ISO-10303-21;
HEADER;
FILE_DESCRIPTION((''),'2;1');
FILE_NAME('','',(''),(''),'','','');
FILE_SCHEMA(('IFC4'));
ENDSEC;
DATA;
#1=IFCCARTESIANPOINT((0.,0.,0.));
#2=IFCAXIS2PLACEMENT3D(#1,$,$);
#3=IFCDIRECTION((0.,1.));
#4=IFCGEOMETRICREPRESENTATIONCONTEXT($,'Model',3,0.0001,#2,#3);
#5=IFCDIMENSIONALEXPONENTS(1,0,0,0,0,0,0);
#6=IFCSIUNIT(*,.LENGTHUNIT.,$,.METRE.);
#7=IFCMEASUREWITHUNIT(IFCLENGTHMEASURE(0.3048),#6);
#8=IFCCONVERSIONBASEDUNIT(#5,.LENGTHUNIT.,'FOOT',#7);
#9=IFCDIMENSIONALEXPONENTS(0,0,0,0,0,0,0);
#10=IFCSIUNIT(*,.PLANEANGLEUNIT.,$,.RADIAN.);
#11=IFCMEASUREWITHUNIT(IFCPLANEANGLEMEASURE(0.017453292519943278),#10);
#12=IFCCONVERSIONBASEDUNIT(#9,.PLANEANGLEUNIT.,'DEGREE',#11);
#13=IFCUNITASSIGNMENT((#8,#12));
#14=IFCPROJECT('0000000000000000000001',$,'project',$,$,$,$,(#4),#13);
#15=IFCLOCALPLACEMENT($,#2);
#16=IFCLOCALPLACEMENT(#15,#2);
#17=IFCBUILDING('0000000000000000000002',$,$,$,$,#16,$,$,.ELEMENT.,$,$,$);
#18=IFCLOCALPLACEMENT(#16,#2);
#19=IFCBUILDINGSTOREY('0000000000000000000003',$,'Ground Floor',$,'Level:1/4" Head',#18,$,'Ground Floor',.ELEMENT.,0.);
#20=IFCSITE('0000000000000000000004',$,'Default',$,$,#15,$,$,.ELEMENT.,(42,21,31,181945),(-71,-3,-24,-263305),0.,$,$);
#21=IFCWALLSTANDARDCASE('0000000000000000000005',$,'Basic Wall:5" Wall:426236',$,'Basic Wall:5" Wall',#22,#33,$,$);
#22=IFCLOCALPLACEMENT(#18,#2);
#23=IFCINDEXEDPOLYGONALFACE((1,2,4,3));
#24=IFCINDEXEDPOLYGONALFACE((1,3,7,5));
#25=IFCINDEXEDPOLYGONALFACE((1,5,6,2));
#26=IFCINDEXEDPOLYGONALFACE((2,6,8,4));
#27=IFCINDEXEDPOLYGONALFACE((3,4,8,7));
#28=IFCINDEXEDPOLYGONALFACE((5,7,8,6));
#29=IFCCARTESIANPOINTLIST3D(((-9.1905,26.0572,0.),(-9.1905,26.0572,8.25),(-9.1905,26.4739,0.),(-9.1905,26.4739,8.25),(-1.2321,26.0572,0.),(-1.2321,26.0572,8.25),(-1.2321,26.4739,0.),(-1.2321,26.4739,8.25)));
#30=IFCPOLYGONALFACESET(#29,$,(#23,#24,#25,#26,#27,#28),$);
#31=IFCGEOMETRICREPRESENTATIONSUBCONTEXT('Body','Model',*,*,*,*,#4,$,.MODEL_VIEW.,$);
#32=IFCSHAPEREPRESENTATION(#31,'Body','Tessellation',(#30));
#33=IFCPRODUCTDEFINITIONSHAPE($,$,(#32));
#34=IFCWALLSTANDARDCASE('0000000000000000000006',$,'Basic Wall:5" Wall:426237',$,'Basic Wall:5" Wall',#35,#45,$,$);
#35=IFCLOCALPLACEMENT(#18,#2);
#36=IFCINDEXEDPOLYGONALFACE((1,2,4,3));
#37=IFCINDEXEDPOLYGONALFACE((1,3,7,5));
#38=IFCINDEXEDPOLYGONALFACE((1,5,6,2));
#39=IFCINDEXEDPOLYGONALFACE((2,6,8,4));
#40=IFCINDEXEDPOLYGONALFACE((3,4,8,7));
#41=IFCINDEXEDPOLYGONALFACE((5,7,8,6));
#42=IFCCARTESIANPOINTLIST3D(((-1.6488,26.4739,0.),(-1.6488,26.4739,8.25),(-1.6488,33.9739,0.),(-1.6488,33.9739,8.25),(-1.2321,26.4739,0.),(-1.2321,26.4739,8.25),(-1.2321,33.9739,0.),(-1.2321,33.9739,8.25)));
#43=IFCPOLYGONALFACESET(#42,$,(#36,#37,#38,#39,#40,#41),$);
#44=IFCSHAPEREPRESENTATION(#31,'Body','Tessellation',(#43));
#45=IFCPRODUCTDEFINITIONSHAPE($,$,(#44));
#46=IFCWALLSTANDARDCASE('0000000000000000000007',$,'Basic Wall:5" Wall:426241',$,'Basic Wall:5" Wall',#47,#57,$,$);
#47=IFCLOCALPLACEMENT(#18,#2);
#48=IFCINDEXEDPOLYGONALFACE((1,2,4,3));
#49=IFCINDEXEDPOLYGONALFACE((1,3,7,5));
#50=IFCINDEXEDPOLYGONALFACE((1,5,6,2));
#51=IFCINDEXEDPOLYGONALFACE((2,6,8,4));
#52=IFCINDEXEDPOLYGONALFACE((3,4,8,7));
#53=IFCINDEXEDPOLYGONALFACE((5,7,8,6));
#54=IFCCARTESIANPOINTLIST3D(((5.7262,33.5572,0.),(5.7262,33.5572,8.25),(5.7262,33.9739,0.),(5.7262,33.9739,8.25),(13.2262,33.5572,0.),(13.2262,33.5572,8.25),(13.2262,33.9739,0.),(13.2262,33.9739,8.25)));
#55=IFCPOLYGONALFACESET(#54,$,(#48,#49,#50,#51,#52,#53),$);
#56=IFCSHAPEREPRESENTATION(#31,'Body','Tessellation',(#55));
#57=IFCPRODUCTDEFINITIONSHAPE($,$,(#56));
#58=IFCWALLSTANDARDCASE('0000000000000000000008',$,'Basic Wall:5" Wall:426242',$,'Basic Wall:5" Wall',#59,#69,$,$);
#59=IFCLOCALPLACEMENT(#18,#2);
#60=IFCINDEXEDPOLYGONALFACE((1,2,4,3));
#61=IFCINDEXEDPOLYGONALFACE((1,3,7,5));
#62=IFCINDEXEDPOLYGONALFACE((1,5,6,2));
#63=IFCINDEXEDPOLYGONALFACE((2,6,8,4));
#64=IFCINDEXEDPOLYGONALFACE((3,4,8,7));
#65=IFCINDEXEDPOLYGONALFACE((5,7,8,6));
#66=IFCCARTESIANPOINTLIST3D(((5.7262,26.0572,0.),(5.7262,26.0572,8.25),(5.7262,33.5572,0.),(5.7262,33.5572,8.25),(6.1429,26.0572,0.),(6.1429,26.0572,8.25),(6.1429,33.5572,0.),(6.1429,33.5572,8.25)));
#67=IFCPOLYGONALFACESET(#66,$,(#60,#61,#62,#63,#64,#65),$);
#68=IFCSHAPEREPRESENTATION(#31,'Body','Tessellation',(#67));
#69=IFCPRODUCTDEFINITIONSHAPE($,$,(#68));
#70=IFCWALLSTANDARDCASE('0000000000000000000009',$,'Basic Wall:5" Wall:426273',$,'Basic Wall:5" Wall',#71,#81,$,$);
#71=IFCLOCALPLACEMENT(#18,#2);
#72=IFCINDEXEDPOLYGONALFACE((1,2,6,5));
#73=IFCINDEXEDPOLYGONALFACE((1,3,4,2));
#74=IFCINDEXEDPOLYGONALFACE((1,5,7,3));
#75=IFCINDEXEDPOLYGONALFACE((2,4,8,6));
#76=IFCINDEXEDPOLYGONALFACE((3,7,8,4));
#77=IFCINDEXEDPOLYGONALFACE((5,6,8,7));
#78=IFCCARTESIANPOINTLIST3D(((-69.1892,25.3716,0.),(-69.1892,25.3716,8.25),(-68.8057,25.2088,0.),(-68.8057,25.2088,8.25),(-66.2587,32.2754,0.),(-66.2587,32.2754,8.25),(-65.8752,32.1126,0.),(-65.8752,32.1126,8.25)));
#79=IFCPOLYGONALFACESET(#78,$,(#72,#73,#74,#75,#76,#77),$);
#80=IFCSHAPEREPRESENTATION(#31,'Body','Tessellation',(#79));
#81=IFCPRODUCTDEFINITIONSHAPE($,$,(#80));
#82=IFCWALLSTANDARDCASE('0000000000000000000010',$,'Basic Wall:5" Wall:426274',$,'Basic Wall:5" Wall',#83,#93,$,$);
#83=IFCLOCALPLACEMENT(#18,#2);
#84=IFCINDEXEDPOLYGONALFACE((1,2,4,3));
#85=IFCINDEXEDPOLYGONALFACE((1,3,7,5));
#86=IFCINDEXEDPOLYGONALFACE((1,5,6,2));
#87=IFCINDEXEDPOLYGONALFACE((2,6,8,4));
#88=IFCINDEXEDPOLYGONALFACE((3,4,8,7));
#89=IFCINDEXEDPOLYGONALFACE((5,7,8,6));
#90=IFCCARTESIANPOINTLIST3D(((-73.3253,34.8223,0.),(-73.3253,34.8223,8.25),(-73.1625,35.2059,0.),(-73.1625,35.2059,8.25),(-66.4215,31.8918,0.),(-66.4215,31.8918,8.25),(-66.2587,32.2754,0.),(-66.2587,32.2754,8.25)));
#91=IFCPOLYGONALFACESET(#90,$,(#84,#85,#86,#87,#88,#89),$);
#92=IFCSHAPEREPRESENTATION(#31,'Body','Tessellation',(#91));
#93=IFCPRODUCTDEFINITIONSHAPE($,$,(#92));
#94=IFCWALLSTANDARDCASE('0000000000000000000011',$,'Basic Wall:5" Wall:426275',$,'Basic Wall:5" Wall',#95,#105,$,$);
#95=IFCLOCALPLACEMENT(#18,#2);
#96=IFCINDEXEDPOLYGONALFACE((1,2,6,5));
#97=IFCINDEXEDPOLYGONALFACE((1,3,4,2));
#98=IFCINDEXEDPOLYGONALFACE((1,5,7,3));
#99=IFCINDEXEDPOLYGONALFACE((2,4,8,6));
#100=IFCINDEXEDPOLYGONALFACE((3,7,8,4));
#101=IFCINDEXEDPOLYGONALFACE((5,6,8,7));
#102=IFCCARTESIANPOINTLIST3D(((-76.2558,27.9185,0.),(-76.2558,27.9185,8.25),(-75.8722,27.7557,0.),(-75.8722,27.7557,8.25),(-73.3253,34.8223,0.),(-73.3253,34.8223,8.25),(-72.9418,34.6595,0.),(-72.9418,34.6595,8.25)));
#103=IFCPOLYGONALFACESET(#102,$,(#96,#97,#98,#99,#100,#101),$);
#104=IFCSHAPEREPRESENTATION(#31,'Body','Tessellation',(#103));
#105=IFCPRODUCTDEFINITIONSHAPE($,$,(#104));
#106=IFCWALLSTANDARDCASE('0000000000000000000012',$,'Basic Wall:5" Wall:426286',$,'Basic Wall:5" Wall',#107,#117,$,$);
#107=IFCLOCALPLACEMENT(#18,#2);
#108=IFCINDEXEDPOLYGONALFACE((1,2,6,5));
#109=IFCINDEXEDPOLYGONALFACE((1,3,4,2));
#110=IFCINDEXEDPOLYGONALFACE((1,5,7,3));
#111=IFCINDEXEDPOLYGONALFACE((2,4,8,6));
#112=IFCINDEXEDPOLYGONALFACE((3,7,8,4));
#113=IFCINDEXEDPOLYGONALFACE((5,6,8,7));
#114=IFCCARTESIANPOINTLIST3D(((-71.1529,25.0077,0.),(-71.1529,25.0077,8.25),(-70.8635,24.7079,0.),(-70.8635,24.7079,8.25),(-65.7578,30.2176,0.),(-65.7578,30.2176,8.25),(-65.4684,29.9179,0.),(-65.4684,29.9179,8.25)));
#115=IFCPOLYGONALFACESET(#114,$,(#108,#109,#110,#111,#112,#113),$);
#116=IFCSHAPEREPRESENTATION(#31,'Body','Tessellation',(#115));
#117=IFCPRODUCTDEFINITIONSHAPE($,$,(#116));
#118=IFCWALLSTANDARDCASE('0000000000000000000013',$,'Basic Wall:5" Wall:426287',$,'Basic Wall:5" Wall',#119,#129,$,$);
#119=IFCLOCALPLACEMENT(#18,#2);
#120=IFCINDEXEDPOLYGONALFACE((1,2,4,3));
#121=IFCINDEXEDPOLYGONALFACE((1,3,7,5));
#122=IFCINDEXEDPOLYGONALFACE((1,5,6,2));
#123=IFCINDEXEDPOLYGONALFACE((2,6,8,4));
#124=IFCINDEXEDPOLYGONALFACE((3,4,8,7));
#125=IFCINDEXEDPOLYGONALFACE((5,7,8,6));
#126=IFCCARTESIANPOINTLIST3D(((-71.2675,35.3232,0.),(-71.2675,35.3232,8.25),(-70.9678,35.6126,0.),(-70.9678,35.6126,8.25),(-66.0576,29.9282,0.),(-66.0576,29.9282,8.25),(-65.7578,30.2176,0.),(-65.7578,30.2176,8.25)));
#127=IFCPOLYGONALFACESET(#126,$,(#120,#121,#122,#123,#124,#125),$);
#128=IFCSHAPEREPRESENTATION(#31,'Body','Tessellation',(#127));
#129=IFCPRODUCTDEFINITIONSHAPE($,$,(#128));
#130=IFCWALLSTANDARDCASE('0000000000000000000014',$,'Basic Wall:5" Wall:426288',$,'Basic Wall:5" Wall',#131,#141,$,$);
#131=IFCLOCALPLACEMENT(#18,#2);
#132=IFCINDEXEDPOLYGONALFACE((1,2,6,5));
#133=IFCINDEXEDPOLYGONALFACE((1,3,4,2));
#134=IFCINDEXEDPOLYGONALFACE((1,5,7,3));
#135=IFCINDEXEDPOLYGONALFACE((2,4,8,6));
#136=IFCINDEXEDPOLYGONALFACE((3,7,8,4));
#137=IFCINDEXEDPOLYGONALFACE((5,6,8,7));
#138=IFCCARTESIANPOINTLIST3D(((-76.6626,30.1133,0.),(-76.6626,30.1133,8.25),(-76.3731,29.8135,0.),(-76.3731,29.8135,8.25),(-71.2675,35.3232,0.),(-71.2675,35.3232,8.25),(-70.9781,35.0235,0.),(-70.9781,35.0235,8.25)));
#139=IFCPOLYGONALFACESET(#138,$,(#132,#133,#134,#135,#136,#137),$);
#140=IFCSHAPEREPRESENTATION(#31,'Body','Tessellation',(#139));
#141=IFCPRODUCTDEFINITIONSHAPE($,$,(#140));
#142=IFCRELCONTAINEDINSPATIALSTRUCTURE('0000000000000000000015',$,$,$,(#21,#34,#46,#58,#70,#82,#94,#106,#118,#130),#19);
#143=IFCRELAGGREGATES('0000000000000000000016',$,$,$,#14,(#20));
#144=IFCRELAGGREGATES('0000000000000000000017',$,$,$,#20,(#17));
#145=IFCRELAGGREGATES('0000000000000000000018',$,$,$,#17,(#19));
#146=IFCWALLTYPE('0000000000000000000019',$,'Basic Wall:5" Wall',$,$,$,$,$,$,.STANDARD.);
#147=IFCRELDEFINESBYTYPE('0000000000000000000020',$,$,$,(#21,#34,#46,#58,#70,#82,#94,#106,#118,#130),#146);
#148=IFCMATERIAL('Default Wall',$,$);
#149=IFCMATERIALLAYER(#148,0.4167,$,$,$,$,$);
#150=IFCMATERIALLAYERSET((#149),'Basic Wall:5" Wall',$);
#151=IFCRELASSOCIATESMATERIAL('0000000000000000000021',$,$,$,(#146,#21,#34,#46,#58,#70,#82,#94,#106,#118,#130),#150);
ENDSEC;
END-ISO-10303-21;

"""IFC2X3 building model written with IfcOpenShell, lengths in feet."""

from ifc_helpers import new_model, entity, si_unit, converted_unit, direction, frame, frame_2d, origin, place, context, subcontext, project, spatial, rectangle, extrude, material, layer, layer_set, layer_usage, type_object, element, save


model = new_model("IFC2X3")

# Units and contexts
model_context = context("Model", 3, precision=0.0001, world=origin(), true_north=direction((0.0, 1.0)))
body_context = subcontext(model_context, "Body", "Model", "MODEL_VIEW")
ifc_project = project(units=[converted_unit("LENGTHUNIT", "FOOT", entity("IfcLengthMeasure", 0.3048), si_unit("LENGTHUNIT", "METRE"), dimensions=[1, 0, 0, 0, 0, 0, 0]), converted_unit("PLANEANGLEUNIT", "DEGREE", entity("IfcPlaneAngleMeasure", 0.017453292519943278), si_unit("PLANEANGLEUNIT", "RADIAN"), dimensions=[0, 0, 0, 0, 0, 0, 0])], contexts=[model_context])

# Site, building, storey
site_placement = place(None, origin())
site = spatial("IfcSite", under=ifc_project, at=site_placement, Name="Default", CompositionType="ELEMENT", RefLatitude=(42, 21, 31, 181945), RefLongitude=(-71, -3, -24, -263305), RefElevation=0.0)
building_placement = place(site_placement, origin())
building = spatial("IfcBuilding", under=site, at=building_placement, CompositionType="ELEMENT")
storey_placement = place(building_placement, origin())
storey = spatial("IfcBuildingStorey", under=building, at=storey_placement, Name="Ground Floor", ObjectType="Level:1/4\" Head", LongName="Ground Floor", CompositionType="ELEMENT", Elevation=0.0)

# Walls
ifc_material = material(Name="Default Wall")
ifc_layer = layer(ifc_material, 0.4167)
ifc_layer_set = layer_set([ifc_layer], Name="Basic Wall:5\" Wall")
ifc_layer_usage_1 = layer_usage(ifc_layer_set, "AXIS2", "NEGATIVE", 0.2083)
wall_type = type_object("IfcWallType", Name="Basic Wall:5\" Wall", PredefinedType="STANDARD", material=ifc_layer_set)
wall_1_placement = place(storey_placement, frame((-1.2321, 26.2656, 0.0), z_axis=(0.0, 0.0, 1.0), x_axis=(-1.0, 0.0, 0.0)))
element("IfcWallStandardCase", 1, at=wall_1_placement, inside=storey, type_object=wall_type, material=ifc_layer_usage_1, Name="Basic Wall:5\" Wall:426236", ObjectType="Basic Wall:5\" Wall", context=body_context, shape_type="SweptSolid", body=[
    extrude(rectangle(XDim=7.9583, YDim=0.4167, at=frame_2d((3.9792, 0.0), x_axis=(-1.0, 0.0))), origin(), (0.0, 0.0, 1.0), 8.25),
])
wall_2_placement = place(storey_placement, frame((-1.4405, 33.9739, 0.0), z_axis=(0.0, 0.0, 1.0), x_axis=(0.0, -1.0, 0.0)))
element("IfcWallStandardCase", 2, at=wall_2_placement, inside=storey, type_object=wall_type, material=ifc_layer_usage_1, Name="Basic Wall:5\" Wall:426237", ObjectType="Basic Wall:5\" Wall", context=body_context, shape_type="SweptSolid", body=[
    extrude(rectangle(XDim=7.5, YDim=0.4167, at=frame_2d((3.75, 0.0), x_axis=(-1.0, 0.0))), origin(), (0.0, 0.0, 1.0), 8.25),
])
wall_3_placement = place(storey_placement, frame((5.7262, 33.7656, 0.0)))
element("IfcWallStandardCase", 3, at=wall_3_placement, inside=storey, type_object=wall_type, material=ifc_layer_usage_1, Name="Basic Wall:5\" Wall:426241", ObjectType="Basic Wall:5\" Wall", context=body_context, shape_type="SweptSolid", body=[
    extrude(rectangle(XDim=7.5, YDim=0.4167, at=frame_2d((3.75, 0.0), x_axis=(-1.0, 0.0))), origin(), (0.0, 0.0, 1.0), 8.25),
])
wall_4_placement = place(storey_placement, frame((5.9345, 26.0572, 0.0), z_axis=(0.0, 0.0, 1.0), x_axis=(0.0, 1.0, 0.0)))
element("IfcWallStandardCase", 4, at=wall_4_placement, inside=storey, type_object=wall_type, material=ifc_layer_usage_1, Name="Basic Wall:5\" Wall:426242", ObjectType="Basic Wall:5\" Wall", context=body_context, shape_type="SweptSolid", body=[
    extrude(rectangle(XDim=7.5, YDim=0.4167, at=frame_2d((3.75, 0.0), x_axis=(-1.0, 0.0))), origin(), (0.0, 0.0, 1.0), 8.25),
])
wall_5_placement = place(storey_placement, frame((-66.0669, 32.194, 0.0), z_axis=(0.0, 0.0, 1.0), x_axis=(-0.390731, -0.920505, 0.0)))
element("IfcWallStandardCase", 5, at=wall_5_placement, inside=storey, type_object=wall_type, material=ifc_layer_usage_1, Name="Basic Wall:5\" Wall:426273", ObjectType="Basic Wall:5\" Wall", context=body_context, shape_type="SweptSolid", body=[
    extrude(rectangle(XDim=7.5, YDim=0.4167, at=frame_2d((3.75, 0.0), x_axis=(-1.0, 0.0))), origin(), (0.0, 0.0, 1.0), 8.25),
])
wall_6_placement = place(storey_placement, frame((-73.2439, 35.0141, 0.0), z_axis=(0.0, 0.0, 1.0), x_axis=(0.920505, -0.390731, 0.0)))
element("IfcWallStandardCase", 6, at=wall_6_placement, inside=storey, type_object=wall_type, material=ifc_layer_usage_1, Name="Basic Wall:5\" Wall:426274", ObjectType="Basic Wall:5\" Wall", context=body_context, shape_type="SweptSolid", body=[
    extrude(rectangle(XDim=7.5, YDim=0.4167, at=frame_2d((3.75, 0.0), x_axis=(-1.0, 0.0))), origin(), (0.0, 0.0, 1.0), 8.25),
])
wall_7_placement = place(storey_placement, frame((-76.064, 27.8371, 0.0), z_axis=(0.0, 0.0, 1.0), x_axis=(0.390731, 0.920505, 0.0)))
element("IfcWallStandardCase", 7, at=wall_7_placement, inside=storey, type_object=wall_type, material=ifc_layer_usage_1, Name="Basic Wall:5\" Wall:426275", ObjectType="Basic Wall:5\" Wall", context=body_context, shape_type="SweptSolid", body=[
    extrude(rectangle(XDim=7.5, YDim=0.4167, at=frame_2d((3.75, 0.0), x_axis=(-1.0, 0.0))), origin(), (0.0, 0.0, 1.0), 8.25),
])
wall_8_placement = place(storey_placement, frame((-65.6131, 30.0677, 0.0), z_axis=(0.0, 0.0, 1.0), x_axis=(-0.71934, -0.694658, 0.0)))
element("IfcWallStandardCase", 8, at=wall_8_placement, inside=storey, type_object=wall_type, material=ifc_layer_usage_1, Name="Basic Wall:5\" Wall:426286", ObjectType="Basic Wall:5\" Wall", context=body_context, shape_type="SweptSolid", body=[
    extrude(rectangle(XDim=7.5, YDim=0.4167, at=frame_2d((3.75, 0.0), x_axis=(-1.0, 0.0))), origin(), (0.0, 0.0, 1.0), 8.25),
])
wall_9_placement = place(storey_placement, frame((-71.1176, 35.4679, 0.0), z_axis=(0.0, 0.0, 1.0), x_axis=(0.694658, -0.71934, 0.0)))
element("IfcWallStandardCase", 9, at=wall_9_placement, inside=storey, type_object=wall_type, material=ifc_layer_usage_1, Name="Basic Wall:5\" Wall:426287", ObjectType="Basic Wall:5\" Wall", context=body_context, shape_type="SweptSolid", body=[
    extrude(rectangle(XDim=7.5, YDim=0.4167, at=frame_2d((3.75, 0.0), x_axis=(-1.0, 0.0))), origin(), (0.0, 0.0, 1.0), 8.25),
])
wall_10_placement = place(storey_placement, frame((-76.5178, 29.9634, 0.0), z_axis=(0.0, 0.0, 1.0), x_axis=(0.71934, 0.694658, 0.0)))
element("IfcWallStandardCase", 10, at=wall_10_placement, inside=storey, type_object=wall_type, material=ifc_layer_usage_1, Name="Basic Wall:5\" Wall:426288", ObjectType="Basic Wall:5\" Wall", context=body_context, shape_type="SweptSolid", body=[
    extrude(rectangle(XDim=7.5, YDim=0.4167, at=frame_2d((3.75, 0.0), x_axis=(-1.0, 0.0))), origin(), (0.0, 0.0, 1.0), 8.25),
])

save(model, "model.ifc")
